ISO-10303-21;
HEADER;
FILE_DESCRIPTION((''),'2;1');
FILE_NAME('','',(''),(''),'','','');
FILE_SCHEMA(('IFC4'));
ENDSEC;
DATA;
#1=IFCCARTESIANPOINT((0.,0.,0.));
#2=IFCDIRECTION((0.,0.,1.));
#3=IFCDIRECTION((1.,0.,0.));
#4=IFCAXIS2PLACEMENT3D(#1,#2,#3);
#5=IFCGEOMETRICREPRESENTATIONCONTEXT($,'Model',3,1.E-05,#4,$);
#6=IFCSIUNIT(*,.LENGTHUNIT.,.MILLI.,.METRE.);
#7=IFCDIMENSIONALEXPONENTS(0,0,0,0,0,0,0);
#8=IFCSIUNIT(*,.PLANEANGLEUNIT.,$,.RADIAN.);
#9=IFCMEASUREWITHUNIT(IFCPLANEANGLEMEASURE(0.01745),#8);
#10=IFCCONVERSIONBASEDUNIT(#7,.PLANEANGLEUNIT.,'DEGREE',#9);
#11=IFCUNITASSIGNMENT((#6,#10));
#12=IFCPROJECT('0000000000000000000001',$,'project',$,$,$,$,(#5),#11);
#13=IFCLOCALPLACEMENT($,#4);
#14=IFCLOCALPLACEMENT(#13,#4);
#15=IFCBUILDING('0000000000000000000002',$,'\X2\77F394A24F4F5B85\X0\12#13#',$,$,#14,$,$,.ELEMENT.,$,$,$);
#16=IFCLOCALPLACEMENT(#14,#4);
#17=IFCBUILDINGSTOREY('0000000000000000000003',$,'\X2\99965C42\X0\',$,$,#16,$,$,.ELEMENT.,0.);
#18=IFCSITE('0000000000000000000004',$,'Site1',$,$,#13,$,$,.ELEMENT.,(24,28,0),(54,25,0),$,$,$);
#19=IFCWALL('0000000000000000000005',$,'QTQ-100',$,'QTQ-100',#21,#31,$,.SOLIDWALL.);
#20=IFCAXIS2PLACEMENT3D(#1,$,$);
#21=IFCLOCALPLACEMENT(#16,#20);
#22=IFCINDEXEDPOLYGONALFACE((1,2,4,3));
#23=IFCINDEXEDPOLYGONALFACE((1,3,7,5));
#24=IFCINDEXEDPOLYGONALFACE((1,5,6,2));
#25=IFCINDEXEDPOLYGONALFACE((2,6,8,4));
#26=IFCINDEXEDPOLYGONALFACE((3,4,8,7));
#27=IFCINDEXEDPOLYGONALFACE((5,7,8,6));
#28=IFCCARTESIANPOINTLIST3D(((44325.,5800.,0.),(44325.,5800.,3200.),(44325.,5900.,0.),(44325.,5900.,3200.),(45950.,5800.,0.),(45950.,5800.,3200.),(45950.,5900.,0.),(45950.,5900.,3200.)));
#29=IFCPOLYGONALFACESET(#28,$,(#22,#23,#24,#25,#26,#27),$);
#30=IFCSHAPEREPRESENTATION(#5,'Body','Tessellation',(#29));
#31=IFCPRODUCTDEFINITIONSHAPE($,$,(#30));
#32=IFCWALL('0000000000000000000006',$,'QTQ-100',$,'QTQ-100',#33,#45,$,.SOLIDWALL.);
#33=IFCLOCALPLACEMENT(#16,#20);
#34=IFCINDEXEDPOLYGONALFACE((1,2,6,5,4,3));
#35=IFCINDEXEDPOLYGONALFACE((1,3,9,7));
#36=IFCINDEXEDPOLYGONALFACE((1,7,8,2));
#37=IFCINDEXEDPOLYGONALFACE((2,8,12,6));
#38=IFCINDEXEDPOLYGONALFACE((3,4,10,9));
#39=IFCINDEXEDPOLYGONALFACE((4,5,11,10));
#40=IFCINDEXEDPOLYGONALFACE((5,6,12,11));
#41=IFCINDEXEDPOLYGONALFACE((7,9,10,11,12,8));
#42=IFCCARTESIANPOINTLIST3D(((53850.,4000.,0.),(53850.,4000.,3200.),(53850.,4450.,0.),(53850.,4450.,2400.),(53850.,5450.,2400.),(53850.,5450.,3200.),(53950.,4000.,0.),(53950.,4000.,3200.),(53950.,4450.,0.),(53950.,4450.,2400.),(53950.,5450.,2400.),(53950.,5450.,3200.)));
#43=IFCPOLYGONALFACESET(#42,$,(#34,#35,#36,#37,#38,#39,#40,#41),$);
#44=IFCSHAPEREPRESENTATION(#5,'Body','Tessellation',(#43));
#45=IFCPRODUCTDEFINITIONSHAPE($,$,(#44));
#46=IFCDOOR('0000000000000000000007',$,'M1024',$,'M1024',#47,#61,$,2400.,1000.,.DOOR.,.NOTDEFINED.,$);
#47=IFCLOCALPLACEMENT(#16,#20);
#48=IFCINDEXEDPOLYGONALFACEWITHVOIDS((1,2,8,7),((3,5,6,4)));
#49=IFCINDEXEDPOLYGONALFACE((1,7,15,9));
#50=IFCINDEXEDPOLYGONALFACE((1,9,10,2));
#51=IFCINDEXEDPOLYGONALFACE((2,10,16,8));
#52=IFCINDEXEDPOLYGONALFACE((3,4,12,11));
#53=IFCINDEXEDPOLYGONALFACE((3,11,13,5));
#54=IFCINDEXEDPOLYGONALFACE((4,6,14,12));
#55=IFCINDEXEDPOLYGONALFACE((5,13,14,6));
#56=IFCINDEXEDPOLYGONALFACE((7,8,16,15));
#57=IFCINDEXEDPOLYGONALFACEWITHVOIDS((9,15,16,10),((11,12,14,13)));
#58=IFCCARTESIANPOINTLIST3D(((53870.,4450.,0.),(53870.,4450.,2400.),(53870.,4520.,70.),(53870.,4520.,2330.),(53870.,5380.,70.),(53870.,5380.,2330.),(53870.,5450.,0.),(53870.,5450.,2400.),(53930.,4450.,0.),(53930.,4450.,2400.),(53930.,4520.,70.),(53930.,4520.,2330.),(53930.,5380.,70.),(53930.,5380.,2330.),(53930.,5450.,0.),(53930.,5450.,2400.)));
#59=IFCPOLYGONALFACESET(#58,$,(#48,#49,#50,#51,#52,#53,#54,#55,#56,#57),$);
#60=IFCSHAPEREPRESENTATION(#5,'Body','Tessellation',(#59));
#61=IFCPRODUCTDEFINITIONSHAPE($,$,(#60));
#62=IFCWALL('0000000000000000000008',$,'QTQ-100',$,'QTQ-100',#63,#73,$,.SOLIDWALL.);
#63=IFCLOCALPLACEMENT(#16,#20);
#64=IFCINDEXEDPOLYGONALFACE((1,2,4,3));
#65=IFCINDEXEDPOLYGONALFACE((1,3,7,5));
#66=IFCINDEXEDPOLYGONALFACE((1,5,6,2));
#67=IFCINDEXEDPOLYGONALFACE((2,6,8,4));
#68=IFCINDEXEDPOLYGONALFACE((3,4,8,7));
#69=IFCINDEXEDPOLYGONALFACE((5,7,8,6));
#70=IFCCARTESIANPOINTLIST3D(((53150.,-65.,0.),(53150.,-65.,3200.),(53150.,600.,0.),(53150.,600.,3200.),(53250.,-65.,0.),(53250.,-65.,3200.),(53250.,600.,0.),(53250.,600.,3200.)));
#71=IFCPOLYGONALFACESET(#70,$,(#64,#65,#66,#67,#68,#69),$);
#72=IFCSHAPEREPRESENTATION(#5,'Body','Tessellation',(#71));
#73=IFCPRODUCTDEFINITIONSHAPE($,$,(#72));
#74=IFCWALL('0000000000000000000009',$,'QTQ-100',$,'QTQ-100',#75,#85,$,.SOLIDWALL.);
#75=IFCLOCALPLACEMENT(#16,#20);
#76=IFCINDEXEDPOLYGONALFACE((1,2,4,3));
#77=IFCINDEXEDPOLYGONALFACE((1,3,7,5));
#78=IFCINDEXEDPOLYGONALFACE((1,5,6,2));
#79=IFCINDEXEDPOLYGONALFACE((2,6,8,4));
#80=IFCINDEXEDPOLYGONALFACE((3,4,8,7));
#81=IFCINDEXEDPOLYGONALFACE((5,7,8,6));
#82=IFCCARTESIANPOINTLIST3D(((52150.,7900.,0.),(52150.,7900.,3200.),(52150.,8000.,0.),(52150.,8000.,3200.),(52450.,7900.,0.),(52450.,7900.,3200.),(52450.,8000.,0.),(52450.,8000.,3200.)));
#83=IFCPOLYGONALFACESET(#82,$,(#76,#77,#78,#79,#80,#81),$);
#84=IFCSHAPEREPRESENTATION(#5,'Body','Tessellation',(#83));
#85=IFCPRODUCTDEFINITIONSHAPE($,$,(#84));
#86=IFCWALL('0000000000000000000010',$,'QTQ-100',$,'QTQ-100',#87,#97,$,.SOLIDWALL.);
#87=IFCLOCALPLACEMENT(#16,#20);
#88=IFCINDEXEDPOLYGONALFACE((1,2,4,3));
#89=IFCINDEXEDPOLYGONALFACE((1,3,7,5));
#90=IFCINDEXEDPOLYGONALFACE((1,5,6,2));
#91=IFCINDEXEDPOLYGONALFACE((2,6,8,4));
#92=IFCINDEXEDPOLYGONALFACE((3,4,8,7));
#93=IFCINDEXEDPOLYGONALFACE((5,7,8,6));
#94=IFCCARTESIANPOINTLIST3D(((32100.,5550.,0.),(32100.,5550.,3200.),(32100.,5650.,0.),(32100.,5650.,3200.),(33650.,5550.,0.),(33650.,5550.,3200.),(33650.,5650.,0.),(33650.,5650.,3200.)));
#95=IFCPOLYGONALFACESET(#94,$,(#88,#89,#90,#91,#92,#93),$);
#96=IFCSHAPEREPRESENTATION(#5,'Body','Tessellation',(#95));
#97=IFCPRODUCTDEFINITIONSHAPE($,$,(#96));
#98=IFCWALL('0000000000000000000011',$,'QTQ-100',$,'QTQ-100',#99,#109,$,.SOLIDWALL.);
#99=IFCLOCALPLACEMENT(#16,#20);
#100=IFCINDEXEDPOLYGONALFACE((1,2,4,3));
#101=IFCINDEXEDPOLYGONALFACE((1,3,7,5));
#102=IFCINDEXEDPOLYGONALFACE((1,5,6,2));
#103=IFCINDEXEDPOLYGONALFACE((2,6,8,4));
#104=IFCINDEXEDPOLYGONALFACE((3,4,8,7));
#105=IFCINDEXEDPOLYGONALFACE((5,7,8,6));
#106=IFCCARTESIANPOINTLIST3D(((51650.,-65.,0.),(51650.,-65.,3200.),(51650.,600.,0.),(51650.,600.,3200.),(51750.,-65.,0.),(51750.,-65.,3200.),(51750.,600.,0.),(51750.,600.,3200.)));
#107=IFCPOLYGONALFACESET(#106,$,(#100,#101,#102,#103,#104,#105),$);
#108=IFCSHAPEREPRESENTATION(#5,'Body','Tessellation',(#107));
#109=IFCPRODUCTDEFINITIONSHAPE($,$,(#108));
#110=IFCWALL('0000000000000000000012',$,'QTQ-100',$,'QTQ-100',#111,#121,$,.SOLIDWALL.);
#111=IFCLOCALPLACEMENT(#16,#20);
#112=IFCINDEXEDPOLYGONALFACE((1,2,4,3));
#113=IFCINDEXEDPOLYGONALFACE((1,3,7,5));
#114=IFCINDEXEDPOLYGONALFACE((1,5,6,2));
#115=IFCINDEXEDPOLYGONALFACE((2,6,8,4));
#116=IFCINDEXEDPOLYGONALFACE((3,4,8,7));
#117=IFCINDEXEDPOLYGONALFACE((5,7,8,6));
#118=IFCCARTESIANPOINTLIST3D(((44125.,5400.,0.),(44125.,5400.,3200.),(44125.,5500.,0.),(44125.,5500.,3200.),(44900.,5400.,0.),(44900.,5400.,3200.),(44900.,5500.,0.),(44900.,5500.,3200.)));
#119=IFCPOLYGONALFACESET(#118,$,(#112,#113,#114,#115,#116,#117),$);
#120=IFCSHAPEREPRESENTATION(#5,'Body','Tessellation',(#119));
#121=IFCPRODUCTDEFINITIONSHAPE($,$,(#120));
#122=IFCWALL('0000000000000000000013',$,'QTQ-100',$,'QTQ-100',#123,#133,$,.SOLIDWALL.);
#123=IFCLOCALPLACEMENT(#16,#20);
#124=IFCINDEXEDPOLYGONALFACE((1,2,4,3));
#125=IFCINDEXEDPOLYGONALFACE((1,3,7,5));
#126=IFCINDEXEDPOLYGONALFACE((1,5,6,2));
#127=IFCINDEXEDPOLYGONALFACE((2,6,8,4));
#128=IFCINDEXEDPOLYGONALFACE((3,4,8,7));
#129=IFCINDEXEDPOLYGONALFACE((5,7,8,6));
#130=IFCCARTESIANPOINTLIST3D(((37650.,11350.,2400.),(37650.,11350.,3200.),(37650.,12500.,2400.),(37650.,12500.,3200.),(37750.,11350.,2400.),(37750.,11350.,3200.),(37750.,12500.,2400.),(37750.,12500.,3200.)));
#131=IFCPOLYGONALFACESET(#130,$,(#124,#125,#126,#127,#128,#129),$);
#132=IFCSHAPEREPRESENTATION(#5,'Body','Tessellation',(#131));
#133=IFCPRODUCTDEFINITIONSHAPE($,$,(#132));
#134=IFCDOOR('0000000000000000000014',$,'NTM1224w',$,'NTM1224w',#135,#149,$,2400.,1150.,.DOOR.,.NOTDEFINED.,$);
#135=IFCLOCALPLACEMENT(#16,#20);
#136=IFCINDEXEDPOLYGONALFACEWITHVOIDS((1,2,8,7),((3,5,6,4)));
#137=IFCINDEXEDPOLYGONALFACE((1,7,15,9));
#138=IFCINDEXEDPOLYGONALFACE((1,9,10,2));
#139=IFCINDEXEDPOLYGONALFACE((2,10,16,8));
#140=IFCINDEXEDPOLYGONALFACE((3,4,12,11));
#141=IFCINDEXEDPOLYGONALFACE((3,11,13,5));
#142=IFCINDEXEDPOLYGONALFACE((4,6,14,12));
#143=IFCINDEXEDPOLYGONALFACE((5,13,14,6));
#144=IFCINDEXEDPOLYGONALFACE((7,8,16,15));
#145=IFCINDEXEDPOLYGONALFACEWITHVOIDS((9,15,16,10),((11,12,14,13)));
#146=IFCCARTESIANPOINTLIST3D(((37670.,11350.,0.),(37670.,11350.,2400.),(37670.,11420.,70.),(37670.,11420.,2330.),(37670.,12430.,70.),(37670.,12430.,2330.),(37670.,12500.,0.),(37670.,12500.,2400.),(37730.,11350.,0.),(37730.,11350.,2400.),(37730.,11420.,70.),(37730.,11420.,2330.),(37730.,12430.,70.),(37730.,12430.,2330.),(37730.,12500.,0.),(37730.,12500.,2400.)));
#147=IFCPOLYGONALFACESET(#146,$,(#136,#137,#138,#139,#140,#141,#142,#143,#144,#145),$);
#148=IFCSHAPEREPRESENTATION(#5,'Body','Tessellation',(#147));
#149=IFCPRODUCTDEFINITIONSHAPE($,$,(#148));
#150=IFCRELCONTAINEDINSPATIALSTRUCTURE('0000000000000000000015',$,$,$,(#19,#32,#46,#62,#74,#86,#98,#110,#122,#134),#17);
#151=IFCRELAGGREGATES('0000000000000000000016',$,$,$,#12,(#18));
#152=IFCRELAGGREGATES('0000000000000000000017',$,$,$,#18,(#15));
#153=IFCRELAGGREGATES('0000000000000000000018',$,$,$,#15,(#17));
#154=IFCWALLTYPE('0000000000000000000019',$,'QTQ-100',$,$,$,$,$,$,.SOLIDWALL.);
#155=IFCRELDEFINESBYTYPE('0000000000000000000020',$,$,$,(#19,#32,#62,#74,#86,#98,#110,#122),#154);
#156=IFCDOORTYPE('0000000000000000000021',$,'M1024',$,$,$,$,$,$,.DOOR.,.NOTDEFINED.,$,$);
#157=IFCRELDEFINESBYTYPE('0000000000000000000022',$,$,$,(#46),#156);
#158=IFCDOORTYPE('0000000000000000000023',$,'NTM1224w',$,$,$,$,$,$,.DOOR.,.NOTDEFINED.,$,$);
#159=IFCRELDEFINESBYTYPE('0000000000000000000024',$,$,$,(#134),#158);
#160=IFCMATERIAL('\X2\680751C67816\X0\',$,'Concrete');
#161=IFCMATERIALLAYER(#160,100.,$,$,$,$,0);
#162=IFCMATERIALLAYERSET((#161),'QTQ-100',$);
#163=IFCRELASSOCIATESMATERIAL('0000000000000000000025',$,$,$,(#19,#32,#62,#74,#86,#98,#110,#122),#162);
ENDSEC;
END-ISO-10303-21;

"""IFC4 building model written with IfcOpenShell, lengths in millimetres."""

from ifc_helpers import new_model, entity, si_unit, converted_unit, frame, origin_with_axes, place, context, project, spatial, polyline, outline, extrude, material, layer, layer_set, type_object, element, fill, save


model = new_model("IFC4")

# Units and contexts
model_context = context("Model", 3, precision=1e-05, world=origin_with_axes())
ifc_project = project(units=[si_unit("LENGTHUNIT", "METRE", prefix="MILLI"), converted_unit("PLANEANGLEUNIT", "DEGREE", entity("IfcPlaneAngleMeasure", 0.01745), si_unit("PLANEANGLEUNIT", "RADIAN"), dimensions=[0, 0, 0, 0, 0, 0, 0])], contexts=[model_context])

# Site, building, storey
site_placement = place(None, origin_with_axes())
site = spatial("IfcSite", under=ifc_project, at=site_placement, Name="Site1", CompositionType="ELEMENT", RefLatitude=(24, 28, 0), RefLongitude=(54, 25, 0))
building_placement = place(site_placement, origin_with_axes())
building = spatial("IfcBuilding", under=site, at=building_placement, Name="石钢住宅12#13#", CompositionType="ELEMENT")
storey_placement = place(building_placement, origin_with_axes())
storey = spatial("IfcBuildingStorey", under=building, at=storey_placement, Name="首层", CompositionType="ELEMENT", Elevation=0.0)

# Shared definitions
ifc_material = material(Name="标准砖", Category="Concrete")
ifc_layer = layer(ifc_material, 100.0, Priority=0)
ifc_layer_set = layer_set([ifc_layer], Name="QTQ-100")
wall_type = type_object("IfcWallType", Name="QTQ-100", PredefinedType="SOLIDWALL")

# Wall
wall_1_placement = place(storey_placement, origin_with_axes())
element("IfcWall", 1, at=wall_1_placement, inside=storey, type_object=wall_type, material=ifc_layer_set, Name="QTQ-100", ObjectType="QTQ-100", PredefinedType="SOLIDWALL", context=model_context, shape_type="SweptSolid", body=[
    extrude(outline(polyline([(0.0, 0.0), (3200.0, 0.0), (3200.0, 1625.0), (0.0, 1625.0), (0.0, 0.0)])), frame((45950.0, 5800.0, 3200.0), z_axis=(0.0, 1.0, 0.0), x_axis=(0.0, 0.0, -1.0)), (0.0, 0.0, 1.0), 100.0),
])

# Wall, opening, door
wall_2_placement = place(storey_placement, origin_with_axes())
wall_2 = element("IfcWall", 2, at=wall_2_placement, inside=storey, type_object=wall_type, material=ifc_layer_set, Name="QTQ-100", ObjectType="QTQ-100", PredefinedType="SOLIDWALL", context=model_context, shape_type="SweptSolid", body=[
    extrude(outline(polyline([(0.0, 0.0), (3200.0, 0.0), (3200.0, 1450.0), (0.0, 1450.0), (0.0, 0.0)])), frame((53950.0, 5450.0, 3200.0), z_axis=(-1.0, 0.0, 0.0), x_axis=(0.0, 0.0, -1.0)), (0.0, 0.0, 1.0), 100.0),
])
opening_1_placement = place(storey_placement, origin_with_axes())
opening_1 = element("IfcOpeningElement", 3, at=opening_1_placement, cuts=wall_2, PredefinedType="OPENING", context=model_context, shape_type="SweptSolid", body=[
    extrude(outline(polyline([(0.0, 0.0), (1000.0, 0.0), (1000.0, 2400.0), (0.0, 2400.0), (0.0, 0.0)])), frame((54950.0, 5450.0, 0.0), z_axis=(-1.0, 0.0, 0.0), x_axis=(0.0, -1.0, 0.0)), (0.0, 0.0, 1.0), 2100.0),
])
door_type_1 = type_object("IfcDoorType", Name="M1024", OperationType="NOTDEFINED", PredefinedType="DOOR")
door_1_placement = place(storey_placement, origin_with_axes())
door_1 = element("IfcDoor", 4, at=door_1_placement, inside=storey, type_object=door_type_1, Name="M1024", ObjectType="M1024", OperationType="NOTDEFINED", OverallHeight=2400.0, OverallWidth=1000.0, PredefinedType="DOOR", context=model_context, shape_type="SweptSolid", body=[
    extrude(outline(polyline([(-500.0, -1200.0), (500.0, -1200.0), (500.0, 1200.0), (-500.0, 1200.0), (-500.0, -1200.0)]), holes=[polyline([(-430.0, -1130.0), (-430.0, 1130.0), (430.0, 1130.0), (430.0, -1130.0), (-430.0, -1130.0)])]), frame((53930.0, 4950.0, 1200.0), z_axis=(-1.0, 0.0, 0.0), x_axis=(0.0, -1.0, 0.0)), (0.0, 0.0, 1.0), 60.0),
])
fill(opening_1, door_1)

# Walls
wall_3_placement = place(storey_placement, origin_with_axes())
element("IfcWall", 5, at=wall_3_placement, inside=storey, type_object=wall_type, material=ifc_layer_set, Name="QTQ-100", ObjectType="QTQ-100", PredefinedType="SOLIDWALL", context=model_context, shape_type="SweptSolid", body=[
    extrude(outline(polyline([(0.0, 0.0), (3200.0, 0.0), (3200.0, 665.0), (0.0, 665.0), (0.0, 0.0)])), frame((53250.0, 600.0, 3200.0), z_axis=(-1.0, 0.0, 0.0), x_axis=(0.0, 0.0, -1.0)), (0.0, 0.0, 1.0), 100.0),
])
wall_4_placement = place(storey_placement, origin_with_axes())
element("IfcWall", 6, at=wall_4_placement, inside=storey, type_object=wall_type, material=ifc_layer_set, Name="QTQ-100", ObjectType="QTQ-100", PredefinedType="SOLIDWALL", context=model_context, shape_type="SweptSolid", body=[
    extrude(outline(polyline([(0.0, 0.0), (3200.0, 0.0), (3200.0, 300.0), (0.0, 300.0), (0.0, 0.0)])), frame((52150.0, 8000.0, 3200.0), z_axis=(0.0, -1.0, 0.0), x_axis=(0.0, 0.0, -1.0)), (0.0, 0.0, 1.0), 100.0),
])
wall_5_placement = place(storey_placement, origin_with_axes())
element("IfcWall", 7, at=wall_5_placement, inside=storey, type_object=wall_type, material=ifc_layer_set, Name="QTQ-100", ObjectType="QTQ-100", PredefinedType="SOLIDWALL", context=model_context, shape_type="SweptSolid", body=[
    extrude(outline(polyline([(0.0, 0.0), (3200.0, 0.0), (3200.0, 1550.0), (0.0, 1550.0), (0.0, 0.0)])), frame((33650.0, 5550.0, 3200.0), z_axis=(0.0, 1.0, 0.0), x_axis=(0.0, 0.0, -1.0)), (0.0, 0.0, 1.0), 100.0),
])
wall_6_placement = place(storey_placement, origin_with_axes())
element("IfcWall", 8, at=wall_6_placement, inside=storey, type_object=wall_type, material=ifc_layer_set, Name="QTQ-100", ObjectType="QTQ-100", PredefinedType="SOLIDWALL", context=model_context, shape_type="SweptSolid", body=[
    extrude(outline(polyline([(0.0, 0.0), (3200.0, 0.0), (3200.0, 665.0), (0.0, 665.0), (0.0, 0.0)])), frame((51750.0, 600.0, 3200.0), z_axis=(-1.0, 0.0, 0.0), x_axis=(0.0, 0.0, -1.0)), (0.0, 0.0, 1.0), 100.0),
])
wall_7_placement = place(storey_placement, origin_with_axes())
element("IfcWall", 9, at=wall_7_placement, inside=storey, type_object=wall_type, material=ifc_layer_set, Name="QTQ-100", ObjectType="QTQ-100", PredefinedType="SOLIDWALL", context=model_context, shape_type="SweptSolid", body=[
    extrude(outline(polyline([(0.0, 0.0), (3200.0, 0.0), (3200.0, 775.0), (0.0, 775.0), (0.0, 0.0)])), frame((44900.0, 5400.0, 3200.0), z_axis=(0.0, 1.0, 0.0), x_axis=(0.0, 0.0, -1.0)), (0.0, 0.0, 1.0), 100.0),
])

# Wall, opening, door
wall_8_placement = place(storey_placement, origin_with_axes())
wall_8 = element("IfcWall", 10, at=wall_8_placement, inside=storey, type_object=wall_type, material=ifc_layer_set, Name="QTQ-100", ObjectType="QTQ-100", PredefinedType="SOLIDWALL", context=model_context, shape_type="SweptSolid", body=[
    extrude(outline(polyline([(0.0, 0.0), (3200.0, 0.0), (3200.0, 1150.0), (0.0, 1150.0), (0.0, 0.0)])), frame((37750.0, 12500.0, 3200.0), z_axis=(-1.0, 0.0, 0.0), x_axis=(0.0, 0.0, -1.0)), (0.0, 0.0, 1.0), 100.0),
])
opening_2_placement = place(storey_placement, origin_with_axes())
opening_2 = element("IfcOpeningElement", 11, at=opening_2_placement, cuts=wall_8, PredefinedType="OPENING", context=model_context, shape_type="SweptSolid", body=[
    extrude(outline(polyline([(0.0, 0.0), (1150.0, 0.0), (1150.0, 2400.0), (0.0, 2400.0), (0.0, 0.0)])), frame((38750.0, 12500.0, 0.0), z_axis=(-1.0, 0.0, 0.0), x_axis=(0.0, -1.0, 0.0)), (0.0, 0.0, 1.0), 2100.0),
])
door_type_2 = type_object("IfcDoorType", Name="NTM1224w", OperationType="NOTDEFINED", PredefinedType="DOOR")
door_2_placement = place(storey_placement, origin_with_axes())
door_2 = element("IfcDoor", 12, at=door_2_placement, inside=storey, type_object=door_type_2, Name="NTM1224w", ObjectType="NTM1224w", OperationType="NOTDEFINED", OverallHeight=2400.0, OverallWidth=1150.0, PredefinedType="DOOR", context=model_context, shape_type="SweptSolid", body=[
    extrude(outline(polyline([(-575.0, -1200.0), (575.0, -1200.0), (575.0, 1200.0), (-575.0, 1200.0), (-575.0, -1200.0)]), holes=[polyline([(-505.0, -1130.0), (-505.0, 1130.0), (505.0, 1130.0), (505.0, -1130.0), (-505.0, -1130.0)])]), frame((37730.0, 11925.0, 1200.0), z_axis=(-1.0, 0.0, 0.0), x_axis=(0.0, -1.0, 0.0)), (0.0, 0.0, 1.0), 60.0),
])
fill(opening_2, door_2)

save(model, "model.ifc")
